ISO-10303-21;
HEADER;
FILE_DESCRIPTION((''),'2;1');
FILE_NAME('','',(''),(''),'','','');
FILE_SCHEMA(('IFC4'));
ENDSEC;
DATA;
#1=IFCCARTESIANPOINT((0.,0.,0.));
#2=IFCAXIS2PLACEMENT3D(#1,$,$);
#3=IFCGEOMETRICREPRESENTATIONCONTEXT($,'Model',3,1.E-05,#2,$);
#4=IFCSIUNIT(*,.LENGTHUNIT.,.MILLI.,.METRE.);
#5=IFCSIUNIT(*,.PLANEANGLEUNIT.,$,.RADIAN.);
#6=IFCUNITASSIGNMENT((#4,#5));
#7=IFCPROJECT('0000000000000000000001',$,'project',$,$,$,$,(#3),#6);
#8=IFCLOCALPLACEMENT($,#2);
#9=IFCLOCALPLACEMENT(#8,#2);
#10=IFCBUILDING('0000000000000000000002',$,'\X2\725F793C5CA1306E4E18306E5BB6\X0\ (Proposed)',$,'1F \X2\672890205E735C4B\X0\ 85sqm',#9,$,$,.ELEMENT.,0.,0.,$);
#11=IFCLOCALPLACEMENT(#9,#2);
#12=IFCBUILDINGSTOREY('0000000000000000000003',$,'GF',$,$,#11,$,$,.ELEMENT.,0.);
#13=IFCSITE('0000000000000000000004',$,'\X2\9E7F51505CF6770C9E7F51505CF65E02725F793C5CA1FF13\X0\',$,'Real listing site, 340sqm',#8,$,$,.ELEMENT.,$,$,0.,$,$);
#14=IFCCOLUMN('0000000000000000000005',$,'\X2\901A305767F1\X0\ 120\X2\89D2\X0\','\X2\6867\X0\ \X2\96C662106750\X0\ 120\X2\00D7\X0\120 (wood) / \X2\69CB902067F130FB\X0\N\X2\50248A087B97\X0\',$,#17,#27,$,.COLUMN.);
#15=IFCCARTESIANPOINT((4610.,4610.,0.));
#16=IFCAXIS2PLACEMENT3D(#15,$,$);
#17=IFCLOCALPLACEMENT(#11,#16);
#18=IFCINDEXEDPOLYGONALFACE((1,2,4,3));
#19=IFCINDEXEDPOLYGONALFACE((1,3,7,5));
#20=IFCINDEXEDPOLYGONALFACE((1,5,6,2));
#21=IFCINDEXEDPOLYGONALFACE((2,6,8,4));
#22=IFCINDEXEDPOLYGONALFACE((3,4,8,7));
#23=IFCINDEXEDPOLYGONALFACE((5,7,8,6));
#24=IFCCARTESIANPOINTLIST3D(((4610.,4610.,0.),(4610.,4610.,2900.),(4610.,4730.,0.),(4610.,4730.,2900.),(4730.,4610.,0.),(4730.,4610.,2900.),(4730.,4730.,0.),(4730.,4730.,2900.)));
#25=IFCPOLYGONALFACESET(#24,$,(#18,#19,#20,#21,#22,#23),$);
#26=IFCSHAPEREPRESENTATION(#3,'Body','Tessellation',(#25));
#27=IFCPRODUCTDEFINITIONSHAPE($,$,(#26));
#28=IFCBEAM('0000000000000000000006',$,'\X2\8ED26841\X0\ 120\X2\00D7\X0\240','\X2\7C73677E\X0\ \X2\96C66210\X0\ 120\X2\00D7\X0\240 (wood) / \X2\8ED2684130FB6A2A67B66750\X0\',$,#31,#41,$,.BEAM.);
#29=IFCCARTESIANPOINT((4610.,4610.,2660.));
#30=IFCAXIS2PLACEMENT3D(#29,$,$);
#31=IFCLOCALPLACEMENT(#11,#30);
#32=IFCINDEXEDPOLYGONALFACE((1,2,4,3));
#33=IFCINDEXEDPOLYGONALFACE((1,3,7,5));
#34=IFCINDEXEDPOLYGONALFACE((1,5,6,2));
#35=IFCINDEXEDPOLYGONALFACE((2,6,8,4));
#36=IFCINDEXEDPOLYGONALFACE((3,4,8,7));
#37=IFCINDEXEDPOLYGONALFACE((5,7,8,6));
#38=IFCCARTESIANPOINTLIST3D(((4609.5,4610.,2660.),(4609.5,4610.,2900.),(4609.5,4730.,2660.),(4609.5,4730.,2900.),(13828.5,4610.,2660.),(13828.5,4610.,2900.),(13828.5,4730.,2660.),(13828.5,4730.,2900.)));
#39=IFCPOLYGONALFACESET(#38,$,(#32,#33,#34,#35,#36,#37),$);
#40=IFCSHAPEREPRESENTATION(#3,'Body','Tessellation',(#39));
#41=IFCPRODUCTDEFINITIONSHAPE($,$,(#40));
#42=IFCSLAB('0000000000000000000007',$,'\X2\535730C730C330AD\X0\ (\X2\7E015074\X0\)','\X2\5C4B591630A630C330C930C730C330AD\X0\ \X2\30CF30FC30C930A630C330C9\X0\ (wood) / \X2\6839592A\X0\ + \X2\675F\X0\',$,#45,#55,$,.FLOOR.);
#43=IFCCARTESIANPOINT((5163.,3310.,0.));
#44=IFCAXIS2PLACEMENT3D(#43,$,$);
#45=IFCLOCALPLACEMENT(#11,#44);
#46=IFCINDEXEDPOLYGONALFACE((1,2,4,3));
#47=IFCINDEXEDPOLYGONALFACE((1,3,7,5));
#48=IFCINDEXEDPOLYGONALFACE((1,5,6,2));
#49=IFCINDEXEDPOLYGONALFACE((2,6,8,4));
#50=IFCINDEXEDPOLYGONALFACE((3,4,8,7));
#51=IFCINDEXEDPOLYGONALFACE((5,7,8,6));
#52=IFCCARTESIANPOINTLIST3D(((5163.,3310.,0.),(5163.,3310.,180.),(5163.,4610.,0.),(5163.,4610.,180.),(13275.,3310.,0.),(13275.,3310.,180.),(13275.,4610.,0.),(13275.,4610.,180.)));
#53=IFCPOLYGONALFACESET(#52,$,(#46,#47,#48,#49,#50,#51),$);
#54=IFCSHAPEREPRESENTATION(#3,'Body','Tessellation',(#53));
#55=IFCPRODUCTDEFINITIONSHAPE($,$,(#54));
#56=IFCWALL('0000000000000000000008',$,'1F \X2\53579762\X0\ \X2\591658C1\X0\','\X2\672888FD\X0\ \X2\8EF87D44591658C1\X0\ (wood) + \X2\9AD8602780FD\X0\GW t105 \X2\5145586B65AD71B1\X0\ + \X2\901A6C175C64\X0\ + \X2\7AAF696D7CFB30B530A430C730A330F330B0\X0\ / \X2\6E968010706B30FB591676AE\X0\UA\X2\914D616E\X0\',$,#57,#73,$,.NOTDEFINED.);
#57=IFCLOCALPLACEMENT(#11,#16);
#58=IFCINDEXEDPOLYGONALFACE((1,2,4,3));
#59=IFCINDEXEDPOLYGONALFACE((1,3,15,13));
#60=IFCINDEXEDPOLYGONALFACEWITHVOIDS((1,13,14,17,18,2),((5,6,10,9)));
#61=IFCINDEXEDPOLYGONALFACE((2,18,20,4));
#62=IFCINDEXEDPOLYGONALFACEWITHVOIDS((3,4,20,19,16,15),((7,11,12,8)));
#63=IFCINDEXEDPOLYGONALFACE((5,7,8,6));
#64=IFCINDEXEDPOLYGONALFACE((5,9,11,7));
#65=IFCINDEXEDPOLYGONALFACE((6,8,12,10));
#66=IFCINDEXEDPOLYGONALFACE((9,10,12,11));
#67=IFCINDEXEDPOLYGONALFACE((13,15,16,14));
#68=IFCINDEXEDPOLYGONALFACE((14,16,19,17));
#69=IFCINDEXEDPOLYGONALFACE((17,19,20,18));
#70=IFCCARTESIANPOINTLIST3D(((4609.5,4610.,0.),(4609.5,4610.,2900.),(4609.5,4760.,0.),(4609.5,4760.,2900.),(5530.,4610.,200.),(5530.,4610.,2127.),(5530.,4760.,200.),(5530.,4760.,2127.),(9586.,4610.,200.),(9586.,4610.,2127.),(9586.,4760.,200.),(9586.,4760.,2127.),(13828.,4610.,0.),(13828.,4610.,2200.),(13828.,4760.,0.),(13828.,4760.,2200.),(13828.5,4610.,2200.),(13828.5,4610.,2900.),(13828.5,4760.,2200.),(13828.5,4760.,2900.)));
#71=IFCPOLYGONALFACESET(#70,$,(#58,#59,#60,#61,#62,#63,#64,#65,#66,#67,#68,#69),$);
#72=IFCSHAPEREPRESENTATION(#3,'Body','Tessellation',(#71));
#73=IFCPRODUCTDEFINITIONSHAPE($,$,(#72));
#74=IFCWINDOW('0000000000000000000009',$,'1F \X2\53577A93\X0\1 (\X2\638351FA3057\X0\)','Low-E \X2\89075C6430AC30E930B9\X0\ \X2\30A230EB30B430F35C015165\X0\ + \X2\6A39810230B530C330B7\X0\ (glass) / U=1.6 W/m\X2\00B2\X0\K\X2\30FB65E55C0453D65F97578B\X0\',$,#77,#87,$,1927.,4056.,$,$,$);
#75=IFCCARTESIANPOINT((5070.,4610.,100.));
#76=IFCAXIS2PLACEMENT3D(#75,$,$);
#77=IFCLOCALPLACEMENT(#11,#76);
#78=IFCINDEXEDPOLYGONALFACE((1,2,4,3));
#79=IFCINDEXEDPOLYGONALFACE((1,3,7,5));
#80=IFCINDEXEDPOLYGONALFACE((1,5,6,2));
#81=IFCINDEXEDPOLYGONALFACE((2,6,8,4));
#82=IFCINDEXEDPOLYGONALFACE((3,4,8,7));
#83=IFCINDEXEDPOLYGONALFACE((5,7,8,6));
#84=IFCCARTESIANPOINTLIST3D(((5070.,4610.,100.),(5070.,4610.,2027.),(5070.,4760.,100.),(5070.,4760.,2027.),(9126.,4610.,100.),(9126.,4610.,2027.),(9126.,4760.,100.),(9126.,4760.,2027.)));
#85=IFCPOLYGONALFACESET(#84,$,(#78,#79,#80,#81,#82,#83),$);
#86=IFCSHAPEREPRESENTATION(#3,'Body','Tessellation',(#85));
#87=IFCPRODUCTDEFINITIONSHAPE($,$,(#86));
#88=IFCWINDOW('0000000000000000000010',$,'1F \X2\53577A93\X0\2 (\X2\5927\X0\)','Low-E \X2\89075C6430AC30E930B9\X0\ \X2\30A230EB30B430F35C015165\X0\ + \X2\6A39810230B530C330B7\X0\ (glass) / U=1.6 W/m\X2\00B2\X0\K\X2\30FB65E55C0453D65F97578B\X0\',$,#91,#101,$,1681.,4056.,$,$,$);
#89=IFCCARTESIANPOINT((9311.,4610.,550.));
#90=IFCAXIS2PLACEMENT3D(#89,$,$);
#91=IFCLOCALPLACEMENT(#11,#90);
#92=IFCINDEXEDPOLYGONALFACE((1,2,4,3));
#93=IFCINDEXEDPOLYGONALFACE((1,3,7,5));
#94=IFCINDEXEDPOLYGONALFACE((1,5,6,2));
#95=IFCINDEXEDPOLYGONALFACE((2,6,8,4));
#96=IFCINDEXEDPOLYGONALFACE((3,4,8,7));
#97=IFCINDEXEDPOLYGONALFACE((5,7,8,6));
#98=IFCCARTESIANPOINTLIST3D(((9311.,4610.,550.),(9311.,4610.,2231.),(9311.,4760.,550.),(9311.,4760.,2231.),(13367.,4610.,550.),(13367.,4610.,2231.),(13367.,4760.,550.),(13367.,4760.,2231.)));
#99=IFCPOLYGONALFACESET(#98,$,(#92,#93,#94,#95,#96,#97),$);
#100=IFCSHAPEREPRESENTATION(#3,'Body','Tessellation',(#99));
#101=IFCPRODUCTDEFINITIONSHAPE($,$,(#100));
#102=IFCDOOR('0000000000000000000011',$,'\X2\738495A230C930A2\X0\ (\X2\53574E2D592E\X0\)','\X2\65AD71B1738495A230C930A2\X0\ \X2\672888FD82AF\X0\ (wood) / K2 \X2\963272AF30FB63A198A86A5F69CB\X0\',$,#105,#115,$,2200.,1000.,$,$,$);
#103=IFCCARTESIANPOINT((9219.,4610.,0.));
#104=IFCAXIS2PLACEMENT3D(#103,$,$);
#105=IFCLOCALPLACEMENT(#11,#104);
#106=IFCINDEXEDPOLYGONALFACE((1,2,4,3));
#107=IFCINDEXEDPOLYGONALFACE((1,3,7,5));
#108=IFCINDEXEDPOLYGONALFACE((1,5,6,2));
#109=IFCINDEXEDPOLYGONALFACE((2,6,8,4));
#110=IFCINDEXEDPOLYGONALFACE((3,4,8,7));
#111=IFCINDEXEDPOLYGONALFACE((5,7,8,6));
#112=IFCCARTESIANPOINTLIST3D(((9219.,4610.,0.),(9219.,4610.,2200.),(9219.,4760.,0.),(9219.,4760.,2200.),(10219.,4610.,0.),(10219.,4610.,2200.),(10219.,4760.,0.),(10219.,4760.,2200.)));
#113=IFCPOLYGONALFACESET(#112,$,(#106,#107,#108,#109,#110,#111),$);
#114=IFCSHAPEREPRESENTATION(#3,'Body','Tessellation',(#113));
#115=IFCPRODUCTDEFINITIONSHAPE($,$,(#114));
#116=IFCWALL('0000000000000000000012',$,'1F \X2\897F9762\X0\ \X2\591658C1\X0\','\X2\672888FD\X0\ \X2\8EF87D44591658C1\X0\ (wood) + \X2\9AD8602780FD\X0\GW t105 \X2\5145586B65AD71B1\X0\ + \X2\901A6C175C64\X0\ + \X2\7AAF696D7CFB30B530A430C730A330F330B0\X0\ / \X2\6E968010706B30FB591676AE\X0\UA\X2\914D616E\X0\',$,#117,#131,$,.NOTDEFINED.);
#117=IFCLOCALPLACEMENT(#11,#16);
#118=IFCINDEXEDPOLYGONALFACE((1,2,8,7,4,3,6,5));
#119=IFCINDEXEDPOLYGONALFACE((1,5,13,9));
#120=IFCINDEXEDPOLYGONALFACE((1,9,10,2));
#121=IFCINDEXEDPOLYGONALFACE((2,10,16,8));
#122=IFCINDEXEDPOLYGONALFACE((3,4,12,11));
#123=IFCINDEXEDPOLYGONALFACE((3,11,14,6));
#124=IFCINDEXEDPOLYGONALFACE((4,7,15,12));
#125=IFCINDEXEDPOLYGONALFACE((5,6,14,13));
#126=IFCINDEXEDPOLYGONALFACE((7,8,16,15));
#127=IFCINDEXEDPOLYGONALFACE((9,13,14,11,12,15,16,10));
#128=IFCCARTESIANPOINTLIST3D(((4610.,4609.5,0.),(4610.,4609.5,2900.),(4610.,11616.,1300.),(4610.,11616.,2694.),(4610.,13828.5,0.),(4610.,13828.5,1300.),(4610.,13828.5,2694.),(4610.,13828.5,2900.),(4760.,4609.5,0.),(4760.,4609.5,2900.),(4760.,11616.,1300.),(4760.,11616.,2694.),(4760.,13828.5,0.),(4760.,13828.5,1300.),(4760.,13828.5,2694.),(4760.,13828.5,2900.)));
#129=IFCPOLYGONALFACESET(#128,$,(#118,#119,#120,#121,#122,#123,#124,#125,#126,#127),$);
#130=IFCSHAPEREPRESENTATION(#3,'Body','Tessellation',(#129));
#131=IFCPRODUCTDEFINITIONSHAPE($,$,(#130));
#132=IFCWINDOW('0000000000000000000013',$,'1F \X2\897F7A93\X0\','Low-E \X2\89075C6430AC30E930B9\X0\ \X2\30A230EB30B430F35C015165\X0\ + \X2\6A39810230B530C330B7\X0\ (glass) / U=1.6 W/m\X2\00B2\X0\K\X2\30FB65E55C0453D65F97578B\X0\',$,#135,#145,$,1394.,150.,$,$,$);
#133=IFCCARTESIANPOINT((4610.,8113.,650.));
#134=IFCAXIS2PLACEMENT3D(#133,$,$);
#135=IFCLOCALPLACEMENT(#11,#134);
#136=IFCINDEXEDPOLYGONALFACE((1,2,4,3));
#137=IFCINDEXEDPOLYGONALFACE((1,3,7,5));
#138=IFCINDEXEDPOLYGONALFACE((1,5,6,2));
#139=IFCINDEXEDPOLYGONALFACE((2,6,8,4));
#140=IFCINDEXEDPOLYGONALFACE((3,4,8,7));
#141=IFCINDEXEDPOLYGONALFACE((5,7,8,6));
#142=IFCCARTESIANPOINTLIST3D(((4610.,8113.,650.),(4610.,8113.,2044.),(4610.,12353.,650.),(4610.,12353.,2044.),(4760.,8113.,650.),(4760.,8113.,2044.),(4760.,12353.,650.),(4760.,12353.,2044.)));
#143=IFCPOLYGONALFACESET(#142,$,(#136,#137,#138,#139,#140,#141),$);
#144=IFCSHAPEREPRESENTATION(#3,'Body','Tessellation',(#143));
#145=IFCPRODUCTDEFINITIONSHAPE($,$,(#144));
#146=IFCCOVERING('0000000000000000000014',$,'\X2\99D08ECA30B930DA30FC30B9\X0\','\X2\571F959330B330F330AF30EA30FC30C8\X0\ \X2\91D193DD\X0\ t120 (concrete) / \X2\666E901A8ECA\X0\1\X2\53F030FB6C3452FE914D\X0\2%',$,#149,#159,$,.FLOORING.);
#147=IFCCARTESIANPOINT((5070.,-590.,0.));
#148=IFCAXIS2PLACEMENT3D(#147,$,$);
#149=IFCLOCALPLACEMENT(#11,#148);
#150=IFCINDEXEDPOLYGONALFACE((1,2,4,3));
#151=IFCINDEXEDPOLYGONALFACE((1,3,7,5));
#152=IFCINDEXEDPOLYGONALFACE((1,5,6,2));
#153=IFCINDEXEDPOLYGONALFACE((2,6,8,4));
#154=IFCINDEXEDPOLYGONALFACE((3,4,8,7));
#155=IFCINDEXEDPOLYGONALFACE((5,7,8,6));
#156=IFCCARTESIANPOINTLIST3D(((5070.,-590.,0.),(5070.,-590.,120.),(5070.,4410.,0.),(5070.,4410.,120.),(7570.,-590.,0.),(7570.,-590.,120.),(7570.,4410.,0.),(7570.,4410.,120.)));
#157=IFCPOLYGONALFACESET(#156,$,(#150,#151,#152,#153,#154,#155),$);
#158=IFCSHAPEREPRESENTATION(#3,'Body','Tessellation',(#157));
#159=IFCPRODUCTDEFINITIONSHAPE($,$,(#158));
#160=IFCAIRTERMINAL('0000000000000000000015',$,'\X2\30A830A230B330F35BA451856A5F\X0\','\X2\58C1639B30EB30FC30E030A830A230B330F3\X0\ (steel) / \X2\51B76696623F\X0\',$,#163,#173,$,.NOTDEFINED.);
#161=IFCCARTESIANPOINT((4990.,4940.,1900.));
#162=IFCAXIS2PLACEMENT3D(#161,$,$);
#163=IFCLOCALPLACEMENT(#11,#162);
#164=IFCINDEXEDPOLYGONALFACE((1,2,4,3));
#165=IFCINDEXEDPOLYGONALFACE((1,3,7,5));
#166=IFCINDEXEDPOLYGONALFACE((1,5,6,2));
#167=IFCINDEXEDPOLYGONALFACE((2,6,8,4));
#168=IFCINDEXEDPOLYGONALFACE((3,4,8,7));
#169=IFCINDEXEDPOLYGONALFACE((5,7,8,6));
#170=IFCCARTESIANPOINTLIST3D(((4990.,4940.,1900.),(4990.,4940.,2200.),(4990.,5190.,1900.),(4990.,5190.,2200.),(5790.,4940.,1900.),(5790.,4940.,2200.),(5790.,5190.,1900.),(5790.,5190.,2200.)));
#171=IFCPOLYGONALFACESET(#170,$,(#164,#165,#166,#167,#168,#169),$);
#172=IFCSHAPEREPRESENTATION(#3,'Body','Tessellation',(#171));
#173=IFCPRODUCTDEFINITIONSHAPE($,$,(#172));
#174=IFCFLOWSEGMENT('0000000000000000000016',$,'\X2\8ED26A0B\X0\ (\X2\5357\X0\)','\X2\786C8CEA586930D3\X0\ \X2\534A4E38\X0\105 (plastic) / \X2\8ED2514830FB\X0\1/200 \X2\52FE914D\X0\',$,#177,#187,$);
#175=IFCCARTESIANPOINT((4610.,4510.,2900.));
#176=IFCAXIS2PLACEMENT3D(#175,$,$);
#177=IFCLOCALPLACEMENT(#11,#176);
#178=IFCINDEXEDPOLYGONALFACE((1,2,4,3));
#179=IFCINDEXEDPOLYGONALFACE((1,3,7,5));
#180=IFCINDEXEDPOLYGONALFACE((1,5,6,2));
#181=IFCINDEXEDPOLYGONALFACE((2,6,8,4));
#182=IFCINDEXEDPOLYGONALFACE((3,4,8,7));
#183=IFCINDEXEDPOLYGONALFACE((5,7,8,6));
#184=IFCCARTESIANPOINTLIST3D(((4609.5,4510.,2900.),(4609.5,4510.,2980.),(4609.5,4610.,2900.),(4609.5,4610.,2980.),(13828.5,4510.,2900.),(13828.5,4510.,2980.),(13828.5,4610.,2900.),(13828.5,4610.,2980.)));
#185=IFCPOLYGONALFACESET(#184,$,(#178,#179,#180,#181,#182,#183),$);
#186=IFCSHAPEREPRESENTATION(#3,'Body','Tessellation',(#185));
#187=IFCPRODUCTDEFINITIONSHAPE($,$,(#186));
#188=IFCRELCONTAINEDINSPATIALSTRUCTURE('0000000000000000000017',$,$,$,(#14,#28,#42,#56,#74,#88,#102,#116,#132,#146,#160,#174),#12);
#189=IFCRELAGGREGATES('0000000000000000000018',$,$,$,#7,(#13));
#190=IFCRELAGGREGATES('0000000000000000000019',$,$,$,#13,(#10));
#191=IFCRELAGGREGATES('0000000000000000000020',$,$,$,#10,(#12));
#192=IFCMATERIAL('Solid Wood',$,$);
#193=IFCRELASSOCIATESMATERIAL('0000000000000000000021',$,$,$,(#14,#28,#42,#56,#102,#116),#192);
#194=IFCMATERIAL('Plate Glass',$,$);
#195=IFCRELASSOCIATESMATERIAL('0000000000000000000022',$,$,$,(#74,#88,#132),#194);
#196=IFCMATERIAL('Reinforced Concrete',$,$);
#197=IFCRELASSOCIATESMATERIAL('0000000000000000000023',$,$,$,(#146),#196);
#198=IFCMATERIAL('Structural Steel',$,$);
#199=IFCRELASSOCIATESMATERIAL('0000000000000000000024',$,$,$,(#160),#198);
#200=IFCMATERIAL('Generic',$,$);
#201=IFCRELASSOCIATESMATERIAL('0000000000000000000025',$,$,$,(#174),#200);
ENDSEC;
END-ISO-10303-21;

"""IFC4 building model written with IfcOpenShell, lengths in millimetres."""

from ifc_helpers import new_model, si_unit, frame, frame_2d, origin, place, context, project, spatial, rectangle, extrude, material, element, fill, save


model = new_model("IFC4")

# Units and contexts
model_context = context("Model", 3, precision=1e-05, world=origin())
ifc_project = project(units=[si_unit("LENGTHUNIT", "METRE", prefix="MILLI"), si_unit("PLANEANGLEUNIT", "RADIAN")], contexts=[model_context])

# Site, building, storey
site_placement = place(None, origin())
site = spatial("IfcSite", under=ifc_project, at=site_placement, Name="鹿児島県鹿児島市牟礼岡３", ObjectType="Real listing site, 340sqm", CompositionType="ELEMENT", RefElevation=0.0)
building_placement = place(site_placement, origin())
building = spatial("IfcBuilding", under=site, at=building_placement, Name="牟礼岡の丘の家 (Proposed)", ObjectType="1F 木造平屋 85sqm", CompositionType="ELEMENT", ElevationOfRefHeight=0.0, ElevationOfTerrain=0.0)
storey_placement = place(building_placement, origin())
storey = spatial("IfcBuildingStorey", under=building, at=storey_placement, Name="GF", CompositionType="ELEMENT", Elevation=0.0)

# Column
ifc_material_1 = material(Name="Solid Wood")
column_1_placement = place(storey_placement, frame((4610.0, 4610.0, 0.0)))
element("IfcColumn", 1, at=column_1_placement, inside=storey, material=ifc_material_1, Name="通し柱 120角", Description="桧 集成材 120×120 (wood) / 構造柱・N値計算", PredefinedType="COLUMN", context=model_context, shape_type="SweptSolid", body=[
    extrude(rectangle(XDim=120.0, YDim=120.0, at=frame_2d((60.0, 60.0))), frame((4610.0, 4610.0, 0.0)), (0.0, 0.0, 1.0), 2900.0),
])

# Beam
beam_1_placement = place(storey_placement, frame((4610.0, 4610.0, 2660.0)))
element("IfcBeam", 2, at=beam_1_placement, inside=storey, material=ifc_material_1, Name="軒桁 120×240", Description="米松 集成 120×240 (wood) / 軒桁・横架材", PredefinedType="BEAM", context=model_context, shape_type="SweptSolid", body=[
    extrude(rectangle(XDim=9219.0, YDim=120.0, at=frame_2d((4609.0, 60.0))), frame((4610.0, 4610.0, 2660.0)), (0.0, 0.0, 1.0), 240.0),
])

# Slab
ifc_material_2 = material(Name="Reinforced Concrete")
slab_1_placement = place(storey_placement, frame((5163.0, 3310.0, 0.0)))
element("IfcSlab", 3, at=slab_1_placement, inside=storey, material=ifc_material_1, Name="南デッキ (縁側)", Description="屋外ウッドデッキ ハードウッド (wood) / 根太 + 束", PredefinedType="FLOOR", context=model_context, shape_type="SweptSolid", body=[
    extrude(rectangle(XDim=8112.0, YDim=1300.0, at=frame_2d((4056.0, 650.0))), frame((5163.0, 3310.0, 0.0)), (0.0, 0.0, 1.0), 180.0),
])

# Wall, openings, windows, door
wall_1_placement = place(storey_placement, frame((4610.0, 4610.0, 0.0)))
wall_1 = element("IfcWall", 4, at=wall_1_placement, inside=storey, material=ifc_material_1, Name="1F 南面 外壁", Description="木製 軸組外壁 (wood) + 高性能GW t105 充填断熱 + 通気層 + 窯業系サイディング / 準耐火・外皮UA配慮", PredefinedType="NOTDEFINED", context=model_context, shape_type="SweptSolid", body=[
    extrude(rectangle(XDim=9219.0, YDim=150.0, at=frame_2d((4609.0, 75.0))), frame((4610.0, 4610.0, 0.0)), (0.0, 0.0, 1.0), 2900.0),
])
opening_1_placement = place(storey_placement, frame((5070.0, 4610.0, 100.0)))
opening_1 = element("IfcOpeningElement", 5, at=opening_1_placement, cuts=wall_1, PredefinedType="NOTDEFINED", context=model_context, shape_type="SweptSolid", body=[
    extrude(rectangle(XDim=4056.0, YDim=150.0, at=frame_2d((2028.0, 75.0))), frame((5070.0, 4610.0, 100.0)), (0.0, 0.0, 1.0), 1927.0),
])
opening_2_placement = place(storey_placement, frame((9311.0, 4610.0, 550.0)))
opening_2 = element("IfcOpeningElement", 6, at=opening_2_placement, cuts=wall_1, PredefinedType="NOTDEFINED", context=model_context, shape_type="SweptSolid", body=[
    extrude(rectangle(XDim=4056.0, YDim=150.0, at=frame_2d((2028.0, 75.0))), frame((9311.0, 4610.0, 550.0)), (0.0, 0.0, 1.0), 1681.0),
])
opening_3_placement = place(storey_placement, frame((9219.0, 4610.0, 0.0)))
opening_3 = element("IfcOpeningElement", 7, at=opening_3_placement, cuts=wall_1, PredefinedType="NOTDEFINED", context=model_context, shape_type="SweptSolid", body=[
    extrude(rectangle(XDim=1000.0, YDim=150.0, at=frame_2d((500.0, 75.0))), frame((9219.0, 4610.0, 0.0)), (0.0, 0.0, 1.0), 2200.0),
])
ifc_material_3 = material(Name="Plate Glass")
window_1_placement = place(storey_placement, frame((5070.0, 4610.0, 100.0)))
window_1 = element("IfcWindow", 8, at=window_1_placement, inside=storey, material=ifc_material_3, Name="1F 南窓1 (掃出し)", Description="Low-E 複層ガラス アルゴン封入 + 樹脂サッシ (glass) / U=1.6 W/m²K・日射取得型", OverallHeight=1927.0, OverallWidth=4056.0, context=model_context, shape_type="SweptSolid", body=[
    extrude(rectangle(XDim=4056.0, YDim=150.0, at=frame_2d((2028.0, 75.0))), frame((5070.0, 4610.0, 100.0)), (0.0, 0.0, 1.0), 1927.0),
])
fill(opening_1, window_1)
window_2_placement = place(storey_placement, frame((9311.0, 4610.0, 550.0)))
window_2 = element("IfcWindow", 9, at=window_2_placement, inside=storey, material=ifc_material_3, Name="1F 南窓2 (大)", Description="Low-E 複層ガラス アルゴン封入 + 樹脂サッシ (glass) / U=1.6 W/m²K・日射取得型", OverallHeight=1681.0, OverallWidth=4056.0, context=model_context, shape_type="SweptSolid", body=[
    extrude(rectangle(XDim=4056.0, YDim=150.0, at=frame_2d((2028.0, 75.0))), frame((9311.0, 4610.0, 550.0)), (0.0, 0.0, 1.0), 1681.0),
])
fill(opening_2, window_2)
door_placement = place(storey_placement, frame((9219.0, 4610.0, 0.0)))
door = element("IfcDoor", 10, at=door_placement, inside=storey, material=ifc_material_1, Name="玄関ドア (南中央)", Description="断熱玄関ドア 木製芯 (wood) / K2 防犯・採風機構", OverallHeight=2200.0, OverallWidth=1000.0, context=model_context, shape_type="SweptSolid", body=[
    extrude(rectangle(XDim=1000.0, YDim=150.0, at=frame_2d((500.0, 75.0))), frame((9219.0, 4610.0, 0.0)), (0.0, 0.0, 1.0), 2200.0),
])
fill(opening_3, door)

# Wall, opening, window
wall_2_placement = place(storey_placement, frame((4610.0, 4610.0, 0.0)))
wall_2 = element("IfcWall", 11, at=wall_2_placement, inside=storey, material=ifc_material_1, Name="1F 西面 外壁", Description="木製 軸組外壁 (wood) + 高性能GW t105 充填断熱 + 通気層 + 窯業系サイディング / 準耐火・外皮UA配慮", PredefinedType="NOTDEFINED", context=model_context, shape_type="SweptSolid", body=[
    extrude(rectangle(XDim=150.0, YDim=9219.0, at=frame_2d((75.0, 4609.0))), frame((4610.0, 4610.0, 0.0)), (0.0, 0.0, 1.0), 2900.0),
])
opening_4_placement = place(storey_placement, frame((4610.0, 8113.0, 650.0)))
opening_4 = element("IfcOpeningElement", 12, at=opening_4_placement, cuts=wall_2, PredefinedType="NOTDEFINED", context=model_context, shape_type="SweptSolid", body=[
    extrude(rectangle(XDim=150.0, YDim=4240.0, at=frame_2d((75.0, 2120.0))), frame((4610.0, 8113.0, 650.0)), (0.0, 0.0, 1.0), 1394.0),
])
window_3_placement = place(storey_placement, frame((4610.0, 8113.0, 650.0)))
window_3 = element("IfcWindow", 13, at=window_3_placement, inside=storey, material=ifc_material_3, Name="1F 西窓", Description="Low-E 複層ガラス アルゴン封入 + 樹脂サッシ (glass) / U=1.6 W/m²K・日射取得型", OverallHeight=1394.0, OverallWidth=150.0, context=model_context, shape_type="SweptSolid", body=[
    extrude(rectangle(XDim=150.0, YDim=4240.0, at=frame_2d((75.0, 2120.0))), frame((4610.0, 8113.0, 650.0)), (0.0, 0.0, 1.0), 1394.0),
])
fill(opening_4, window_3)

# Shared definitions
ifc_material_4 = material(Name="Structural Steel")

# Covering
ifc_material_5 = material(Name="Generic")
covering_1_placement = place(storey_placement, frame((5070.0, -590.0, 0.0)))
element("IfcCovering", 14, at=covering_1_placement, inside=storey, material=ifc_material_2, Name="駐車スペース", Description="土間コンクリート 金鏝 t120 (concrete) / 普通車1台・水勾配2%", PredefinedType="FLOORING", context=model_context, shape_type="SweptSolid", body=[
    extrude(rectangle(XDim=2500.0, YDim=5000.0, at=frame_2d((1250.0, 2500.0))), frame((5070.0, -590.0, 0.0)), (0.0, 0.0, 1.0), 120.0),
])

# Air terminal
air_terminal_placement = place(storey_placement, frame((4990.0, 4940.0, 1900.0)))
element("IfcAirTerminal", 15, at=air_terminal_placement, inside=storey, material=ifc_material_4, Name="エアコン室内機", Description="壁掛ルームエアコン (steel) / 冷暖房", PredefinedType="NOTDEFINED", context=model_context, shape_type="SweptSolid", body=[
    extrude(rectangle(XDim=800.0, YDim=250.0, at=frame_2d((400.0, 125.0))), frame((4990.0, 4940.0, 1900.0)), (0.0, 0.0, 1.0), 300.0),
])

# Flow segment
flow_segment_1_placement = place(storey_placement, frame((4610.0, 4510.0, 2900.0)))
element("IfcFlowSegment", 16, at=flow_segment_1_placement, inside=storey, material=ifc_material_5, Name="軒樋 (南)", Description="硬質塩ビ 半丸105 (plastic) / 軒先・1/200 勾配", context=model_context, shape_type="SweptSolid", body=[
    extrude(rectangle(XDim=9219.0, YDim=100.0, at=frame_2d((4609.0, 50.0))), frame((4610.0, 4510.0, 2900.0)), (0.0, 0.0, 1.0), 80.0),
])

save(model, "model.ifc")
